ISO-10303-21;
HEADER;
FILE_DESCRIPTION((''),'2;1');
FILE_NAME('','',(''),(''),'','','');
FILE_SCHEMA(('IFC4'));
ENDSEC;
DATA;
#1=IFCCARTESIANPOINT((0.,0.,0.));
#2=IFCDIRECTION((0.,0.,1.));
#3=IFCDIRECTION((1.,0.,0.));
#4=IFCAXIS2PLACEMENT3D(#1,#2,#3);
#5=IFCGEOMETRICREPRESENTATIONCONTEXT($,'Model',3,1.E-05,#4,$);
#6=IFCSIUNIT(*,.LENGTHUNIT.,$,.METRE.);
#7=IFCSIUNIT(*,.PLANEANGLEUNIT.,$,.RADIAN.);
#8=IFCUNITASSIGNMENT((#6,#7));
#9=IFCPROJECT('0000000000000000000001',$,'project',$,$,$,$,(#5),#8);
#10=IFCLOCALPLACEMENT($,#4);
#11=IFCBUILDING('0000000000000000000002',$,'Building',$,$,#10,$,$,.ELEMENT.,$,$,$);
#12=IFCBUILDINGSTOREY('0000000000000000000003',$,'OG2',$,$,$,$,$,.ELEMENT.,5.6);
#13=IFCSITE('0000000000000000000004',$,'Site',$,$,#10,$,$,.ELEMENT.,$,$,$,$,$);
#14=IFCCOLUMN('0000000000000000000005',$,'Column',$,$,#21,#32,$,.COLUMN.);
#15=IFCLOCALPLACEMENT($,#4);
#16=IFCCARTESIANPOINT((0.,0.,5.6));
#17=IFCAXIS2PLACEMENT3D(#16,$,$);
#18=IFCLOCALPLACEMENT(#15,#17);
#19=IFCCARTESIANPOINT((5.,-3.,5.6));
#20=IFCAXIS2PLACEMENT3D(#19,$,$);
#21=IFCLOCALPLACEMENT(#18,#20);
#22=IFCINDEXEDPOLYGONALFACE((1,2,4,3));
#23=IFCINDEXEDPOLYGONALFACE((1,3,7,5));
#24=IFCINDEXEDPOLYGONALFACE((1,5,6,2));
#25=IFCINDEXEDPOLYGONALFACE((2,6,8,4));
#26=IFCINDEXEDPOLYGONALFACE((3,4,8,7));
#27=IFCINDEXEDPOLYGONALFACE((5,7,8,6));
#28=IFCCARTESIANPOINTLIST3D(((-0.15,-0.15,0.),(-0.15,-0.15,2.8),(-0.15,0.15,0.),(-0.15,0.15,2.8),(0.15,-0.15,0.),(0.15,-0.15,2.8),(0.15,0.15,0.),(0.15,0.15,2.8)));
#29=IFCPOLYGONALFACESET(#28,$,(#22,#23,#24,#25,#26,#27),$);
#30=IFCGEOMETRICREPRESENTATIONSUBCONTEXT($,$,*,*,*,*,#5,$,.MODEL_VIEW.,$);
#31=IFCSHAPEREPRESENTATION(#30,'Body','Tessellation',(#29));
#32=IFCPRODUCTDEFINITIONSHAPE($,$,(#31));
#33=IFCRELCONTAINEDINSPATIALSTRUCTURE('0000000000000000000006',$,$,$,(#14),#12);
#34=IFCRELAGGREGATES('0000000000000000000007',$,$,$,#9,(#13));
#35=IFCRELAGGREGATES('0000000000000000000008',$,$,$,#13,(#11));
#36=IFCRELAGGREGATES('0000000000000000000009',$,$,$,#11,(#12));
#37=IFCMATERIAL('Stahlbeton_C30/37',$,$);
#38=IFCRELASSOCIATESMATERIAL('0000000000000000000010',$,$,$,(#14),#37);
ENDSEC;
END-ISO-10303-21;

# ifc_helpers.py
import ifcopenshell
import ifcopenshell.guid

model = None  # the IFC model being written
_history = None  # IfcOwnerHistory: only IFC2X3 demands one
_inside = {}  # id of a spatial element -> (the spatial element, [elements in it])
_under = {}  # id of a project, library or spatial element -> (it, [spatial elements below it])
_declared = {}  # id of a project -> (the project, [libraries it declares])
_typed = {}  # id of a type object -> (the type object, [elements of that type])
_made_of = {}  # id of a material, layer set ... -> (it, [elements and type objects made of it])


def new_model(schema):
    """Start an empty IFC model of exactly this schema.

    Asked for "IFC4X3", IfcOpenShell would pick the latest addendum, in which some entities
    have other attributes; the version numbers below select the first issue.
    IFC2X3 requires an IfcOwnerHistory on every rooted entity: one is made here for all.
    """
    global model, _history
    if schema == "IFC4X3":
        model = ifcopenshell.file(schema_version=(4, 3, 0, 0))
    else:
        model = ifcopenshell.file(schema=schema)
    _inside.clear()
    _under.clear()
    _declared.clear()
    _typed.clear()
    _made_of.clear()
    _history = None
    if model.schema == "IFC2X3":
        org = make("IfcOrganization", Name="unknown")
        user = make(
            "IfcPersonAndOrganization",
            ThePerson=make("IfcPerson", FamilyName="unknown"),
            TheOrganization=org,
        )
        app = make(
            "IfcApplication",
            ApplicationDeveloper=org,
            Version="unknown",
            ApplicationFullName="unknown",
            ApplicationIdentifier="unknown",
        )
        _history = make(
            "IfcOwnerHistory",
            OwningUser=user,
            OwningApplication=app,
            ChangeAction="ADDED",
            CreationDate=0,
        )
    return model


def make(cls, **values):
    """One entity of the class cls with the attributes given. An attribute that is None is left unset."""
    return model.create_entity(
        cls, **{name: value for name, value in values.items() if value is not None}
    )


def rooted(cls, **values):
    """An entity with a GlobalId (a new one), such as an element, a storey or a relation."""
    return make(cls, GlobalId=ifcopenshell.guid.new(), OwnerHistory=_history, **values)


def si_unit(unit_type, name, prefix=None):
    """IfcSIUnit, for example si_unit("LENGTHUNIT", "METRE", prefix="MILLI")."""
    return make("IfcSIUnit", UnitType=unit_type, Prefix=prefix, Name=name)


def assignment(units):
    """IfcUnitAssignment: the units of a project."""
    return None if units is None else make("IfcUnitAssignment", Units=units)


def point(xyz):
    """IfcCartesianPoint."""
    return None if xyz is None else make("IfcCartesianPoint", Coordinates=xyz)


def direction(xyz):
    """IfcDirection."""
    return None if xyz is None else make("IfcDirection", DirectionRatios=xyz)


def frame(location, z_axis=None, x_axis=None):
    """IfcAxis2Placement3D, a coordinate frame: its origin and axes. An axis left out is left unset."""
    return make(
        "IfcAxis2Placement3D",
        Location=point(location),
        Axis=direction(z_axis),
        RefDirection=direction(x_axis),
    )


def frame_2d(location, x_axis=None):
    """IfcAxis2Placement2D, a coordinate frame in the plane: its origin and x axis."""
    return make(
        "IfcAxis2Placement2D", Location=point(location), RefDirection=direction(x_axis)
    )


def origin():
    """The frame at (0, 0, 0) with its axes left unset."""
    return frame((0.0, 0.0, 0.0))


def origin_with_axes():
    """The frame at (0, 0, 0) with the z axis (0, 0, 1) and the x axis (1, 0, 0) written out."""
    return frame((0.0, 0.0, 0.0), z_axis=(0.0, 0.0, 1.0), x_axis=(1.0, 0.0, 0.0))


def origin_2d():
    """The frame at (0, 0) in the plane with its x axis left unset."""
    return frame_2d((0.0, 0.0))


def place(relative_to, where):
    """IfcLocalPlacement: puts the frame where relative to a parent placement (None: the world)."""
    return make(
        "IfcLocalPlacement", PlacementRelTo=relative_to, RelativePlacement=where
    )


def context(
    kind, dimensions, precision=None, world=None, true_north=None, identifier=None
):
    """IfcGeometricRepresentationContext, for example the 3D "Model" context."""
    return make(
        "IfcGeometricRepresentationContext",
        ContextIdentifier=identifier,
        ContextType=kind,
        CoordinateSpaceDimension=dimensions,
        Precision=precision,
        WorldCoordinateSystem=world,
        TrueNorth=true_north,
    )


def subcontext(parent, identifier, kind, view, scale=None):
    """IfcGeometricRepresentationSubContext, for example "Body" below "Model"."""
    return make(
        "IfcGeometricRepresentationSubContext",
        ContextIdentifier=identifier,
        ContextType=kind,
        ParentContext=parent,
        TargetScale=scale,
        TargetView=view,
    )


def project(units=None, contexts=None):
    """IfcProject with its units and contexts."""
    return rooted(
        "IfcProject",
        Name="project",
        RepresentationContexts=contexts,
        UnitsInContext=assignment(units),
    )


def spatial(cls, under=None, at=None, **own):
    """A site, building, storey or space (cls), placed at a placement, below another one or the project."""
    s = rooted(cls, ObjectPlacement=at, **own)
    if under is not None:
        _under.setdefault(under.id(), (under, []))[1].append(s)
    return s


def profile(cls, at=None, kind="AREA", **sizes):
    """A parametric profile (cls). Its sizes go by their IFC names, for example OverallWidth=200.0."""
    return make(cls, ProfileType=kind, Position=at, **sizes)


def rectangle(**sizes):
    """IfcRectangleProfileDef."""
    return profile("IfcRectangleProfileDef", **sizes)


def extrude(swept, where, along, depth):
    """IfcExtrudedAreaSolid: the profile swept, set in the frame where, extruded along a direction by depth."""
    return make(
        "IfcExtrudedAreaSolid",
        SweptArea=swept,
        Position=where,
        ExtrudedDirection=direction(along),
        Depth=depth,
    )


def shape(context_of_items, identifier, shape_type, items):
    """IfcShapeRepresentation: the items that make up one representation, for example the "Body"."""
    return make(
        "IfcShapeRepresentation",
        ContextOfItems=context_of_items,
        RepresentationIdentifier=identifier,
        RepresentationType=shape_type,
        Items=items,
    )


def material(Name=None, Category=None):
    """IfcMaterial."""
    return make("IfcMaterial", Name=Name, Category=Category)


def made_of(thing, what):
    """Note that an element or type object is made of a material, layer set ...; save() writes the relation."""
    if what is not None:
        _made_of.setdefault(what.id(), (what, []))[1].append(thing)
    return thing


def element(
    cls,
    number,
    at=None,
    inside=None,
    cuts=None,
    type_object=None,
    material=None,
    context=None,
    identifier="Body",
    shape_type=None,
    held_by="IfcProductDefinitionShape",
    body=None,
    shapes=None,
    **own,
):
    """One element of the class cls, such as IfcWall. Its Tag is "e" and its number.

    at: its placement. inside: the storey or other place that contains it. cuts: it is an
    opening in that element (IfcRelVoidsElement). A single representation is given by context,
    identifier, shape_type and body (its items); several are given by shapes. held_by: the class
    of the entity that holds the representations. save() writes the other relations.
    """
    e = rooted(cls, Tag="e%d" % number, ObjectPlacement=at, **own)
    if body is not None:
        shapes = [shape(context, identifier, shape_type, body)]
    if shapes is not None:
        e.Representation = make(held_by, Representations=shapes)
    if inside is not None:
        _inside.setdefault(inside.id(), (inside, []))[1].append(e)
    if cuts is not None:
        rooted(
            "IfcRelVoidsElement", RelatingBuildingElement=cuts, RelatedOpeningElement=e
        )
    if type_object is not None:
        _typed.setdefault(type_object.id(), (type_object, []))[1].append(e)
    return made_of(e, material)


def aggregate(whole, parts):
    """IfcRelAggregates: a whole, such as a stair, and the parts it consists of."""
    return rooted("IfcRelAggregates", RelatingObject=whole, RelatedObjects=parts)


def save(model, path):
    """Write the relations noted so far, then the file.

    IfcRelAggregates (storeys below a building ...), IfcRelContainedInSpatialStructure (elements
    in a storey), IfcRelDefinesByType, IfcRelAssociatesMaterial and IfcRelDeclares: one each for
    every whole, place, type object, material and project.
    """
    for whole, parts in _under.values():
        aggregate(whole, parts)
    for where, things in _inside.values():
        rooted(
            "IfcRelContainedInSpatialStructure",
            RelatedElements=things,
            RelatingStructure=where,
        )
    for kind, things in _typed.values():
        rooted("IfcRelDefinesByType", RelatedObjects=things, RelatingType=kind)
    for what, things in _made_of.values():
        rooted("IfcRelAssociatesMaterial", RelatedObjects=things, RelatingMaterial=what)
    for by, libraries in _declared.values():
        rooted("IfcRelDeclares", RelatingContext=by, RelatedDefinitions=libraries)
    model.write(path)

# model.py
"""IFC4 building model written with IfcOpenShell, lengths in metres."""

from ifc_helpers import new_model, si_unit, frame, origin, origin_with_axes, origin_2d, place, context, subcontext, project, spatial, rectangle, extrude, material, element, save


model = new_model("IFC4")

# Units and contexts
model_context = context("Model", 3, precision=1e-05, world=origin_with_axes())
sub_context = subcontext(model_context, None, None, "MODEL_VIEW")
ifc_project = project(units=[si_unit("LENGTHUNIT", "METRE"), si_unit("PLANEANGLEUNIT", "RADIAN")], contexts=[model_context])

# Site, building, storey
placement_1 = place(None, origin_with_axes())
site = spatial("IfcSite", under=ifc_project, at=placement_1, Name="Site", CompositionType="ELEMENT")
building = spatial("IfcBuilding", under=site, at=placement_1, Name="Building", CompositionType="ELEMENT")
storey = spatial("IfcBuildingStorey", under=building, Name="OG2", CompositionType="ELEMENT", Elevation=5.6)

# Column
ifc_material = material(Name="Stahlbeton_C30/37")
placement_2 = place(None, origin_with_axes())
placement_3 = place(placement_2, frame((0.0, 0.0, 5.6)))
column_placement = place(placement_3, frame((5.0, -3.0, 5.6)))
element("IfcColumn", 1, at=column_placement, inside=storey, material=ifc_material, Name="Column", PredefinedType="COLUMN", context=sub_context, shape_type="SweptSolid", body=[
    extrude(rectangle(XDim=0.3, YDim=0.3, at=origin_2d()), origin(), (0.0, 0.0, 1.0), 2.8),
])

save(model, "model.ifc")
